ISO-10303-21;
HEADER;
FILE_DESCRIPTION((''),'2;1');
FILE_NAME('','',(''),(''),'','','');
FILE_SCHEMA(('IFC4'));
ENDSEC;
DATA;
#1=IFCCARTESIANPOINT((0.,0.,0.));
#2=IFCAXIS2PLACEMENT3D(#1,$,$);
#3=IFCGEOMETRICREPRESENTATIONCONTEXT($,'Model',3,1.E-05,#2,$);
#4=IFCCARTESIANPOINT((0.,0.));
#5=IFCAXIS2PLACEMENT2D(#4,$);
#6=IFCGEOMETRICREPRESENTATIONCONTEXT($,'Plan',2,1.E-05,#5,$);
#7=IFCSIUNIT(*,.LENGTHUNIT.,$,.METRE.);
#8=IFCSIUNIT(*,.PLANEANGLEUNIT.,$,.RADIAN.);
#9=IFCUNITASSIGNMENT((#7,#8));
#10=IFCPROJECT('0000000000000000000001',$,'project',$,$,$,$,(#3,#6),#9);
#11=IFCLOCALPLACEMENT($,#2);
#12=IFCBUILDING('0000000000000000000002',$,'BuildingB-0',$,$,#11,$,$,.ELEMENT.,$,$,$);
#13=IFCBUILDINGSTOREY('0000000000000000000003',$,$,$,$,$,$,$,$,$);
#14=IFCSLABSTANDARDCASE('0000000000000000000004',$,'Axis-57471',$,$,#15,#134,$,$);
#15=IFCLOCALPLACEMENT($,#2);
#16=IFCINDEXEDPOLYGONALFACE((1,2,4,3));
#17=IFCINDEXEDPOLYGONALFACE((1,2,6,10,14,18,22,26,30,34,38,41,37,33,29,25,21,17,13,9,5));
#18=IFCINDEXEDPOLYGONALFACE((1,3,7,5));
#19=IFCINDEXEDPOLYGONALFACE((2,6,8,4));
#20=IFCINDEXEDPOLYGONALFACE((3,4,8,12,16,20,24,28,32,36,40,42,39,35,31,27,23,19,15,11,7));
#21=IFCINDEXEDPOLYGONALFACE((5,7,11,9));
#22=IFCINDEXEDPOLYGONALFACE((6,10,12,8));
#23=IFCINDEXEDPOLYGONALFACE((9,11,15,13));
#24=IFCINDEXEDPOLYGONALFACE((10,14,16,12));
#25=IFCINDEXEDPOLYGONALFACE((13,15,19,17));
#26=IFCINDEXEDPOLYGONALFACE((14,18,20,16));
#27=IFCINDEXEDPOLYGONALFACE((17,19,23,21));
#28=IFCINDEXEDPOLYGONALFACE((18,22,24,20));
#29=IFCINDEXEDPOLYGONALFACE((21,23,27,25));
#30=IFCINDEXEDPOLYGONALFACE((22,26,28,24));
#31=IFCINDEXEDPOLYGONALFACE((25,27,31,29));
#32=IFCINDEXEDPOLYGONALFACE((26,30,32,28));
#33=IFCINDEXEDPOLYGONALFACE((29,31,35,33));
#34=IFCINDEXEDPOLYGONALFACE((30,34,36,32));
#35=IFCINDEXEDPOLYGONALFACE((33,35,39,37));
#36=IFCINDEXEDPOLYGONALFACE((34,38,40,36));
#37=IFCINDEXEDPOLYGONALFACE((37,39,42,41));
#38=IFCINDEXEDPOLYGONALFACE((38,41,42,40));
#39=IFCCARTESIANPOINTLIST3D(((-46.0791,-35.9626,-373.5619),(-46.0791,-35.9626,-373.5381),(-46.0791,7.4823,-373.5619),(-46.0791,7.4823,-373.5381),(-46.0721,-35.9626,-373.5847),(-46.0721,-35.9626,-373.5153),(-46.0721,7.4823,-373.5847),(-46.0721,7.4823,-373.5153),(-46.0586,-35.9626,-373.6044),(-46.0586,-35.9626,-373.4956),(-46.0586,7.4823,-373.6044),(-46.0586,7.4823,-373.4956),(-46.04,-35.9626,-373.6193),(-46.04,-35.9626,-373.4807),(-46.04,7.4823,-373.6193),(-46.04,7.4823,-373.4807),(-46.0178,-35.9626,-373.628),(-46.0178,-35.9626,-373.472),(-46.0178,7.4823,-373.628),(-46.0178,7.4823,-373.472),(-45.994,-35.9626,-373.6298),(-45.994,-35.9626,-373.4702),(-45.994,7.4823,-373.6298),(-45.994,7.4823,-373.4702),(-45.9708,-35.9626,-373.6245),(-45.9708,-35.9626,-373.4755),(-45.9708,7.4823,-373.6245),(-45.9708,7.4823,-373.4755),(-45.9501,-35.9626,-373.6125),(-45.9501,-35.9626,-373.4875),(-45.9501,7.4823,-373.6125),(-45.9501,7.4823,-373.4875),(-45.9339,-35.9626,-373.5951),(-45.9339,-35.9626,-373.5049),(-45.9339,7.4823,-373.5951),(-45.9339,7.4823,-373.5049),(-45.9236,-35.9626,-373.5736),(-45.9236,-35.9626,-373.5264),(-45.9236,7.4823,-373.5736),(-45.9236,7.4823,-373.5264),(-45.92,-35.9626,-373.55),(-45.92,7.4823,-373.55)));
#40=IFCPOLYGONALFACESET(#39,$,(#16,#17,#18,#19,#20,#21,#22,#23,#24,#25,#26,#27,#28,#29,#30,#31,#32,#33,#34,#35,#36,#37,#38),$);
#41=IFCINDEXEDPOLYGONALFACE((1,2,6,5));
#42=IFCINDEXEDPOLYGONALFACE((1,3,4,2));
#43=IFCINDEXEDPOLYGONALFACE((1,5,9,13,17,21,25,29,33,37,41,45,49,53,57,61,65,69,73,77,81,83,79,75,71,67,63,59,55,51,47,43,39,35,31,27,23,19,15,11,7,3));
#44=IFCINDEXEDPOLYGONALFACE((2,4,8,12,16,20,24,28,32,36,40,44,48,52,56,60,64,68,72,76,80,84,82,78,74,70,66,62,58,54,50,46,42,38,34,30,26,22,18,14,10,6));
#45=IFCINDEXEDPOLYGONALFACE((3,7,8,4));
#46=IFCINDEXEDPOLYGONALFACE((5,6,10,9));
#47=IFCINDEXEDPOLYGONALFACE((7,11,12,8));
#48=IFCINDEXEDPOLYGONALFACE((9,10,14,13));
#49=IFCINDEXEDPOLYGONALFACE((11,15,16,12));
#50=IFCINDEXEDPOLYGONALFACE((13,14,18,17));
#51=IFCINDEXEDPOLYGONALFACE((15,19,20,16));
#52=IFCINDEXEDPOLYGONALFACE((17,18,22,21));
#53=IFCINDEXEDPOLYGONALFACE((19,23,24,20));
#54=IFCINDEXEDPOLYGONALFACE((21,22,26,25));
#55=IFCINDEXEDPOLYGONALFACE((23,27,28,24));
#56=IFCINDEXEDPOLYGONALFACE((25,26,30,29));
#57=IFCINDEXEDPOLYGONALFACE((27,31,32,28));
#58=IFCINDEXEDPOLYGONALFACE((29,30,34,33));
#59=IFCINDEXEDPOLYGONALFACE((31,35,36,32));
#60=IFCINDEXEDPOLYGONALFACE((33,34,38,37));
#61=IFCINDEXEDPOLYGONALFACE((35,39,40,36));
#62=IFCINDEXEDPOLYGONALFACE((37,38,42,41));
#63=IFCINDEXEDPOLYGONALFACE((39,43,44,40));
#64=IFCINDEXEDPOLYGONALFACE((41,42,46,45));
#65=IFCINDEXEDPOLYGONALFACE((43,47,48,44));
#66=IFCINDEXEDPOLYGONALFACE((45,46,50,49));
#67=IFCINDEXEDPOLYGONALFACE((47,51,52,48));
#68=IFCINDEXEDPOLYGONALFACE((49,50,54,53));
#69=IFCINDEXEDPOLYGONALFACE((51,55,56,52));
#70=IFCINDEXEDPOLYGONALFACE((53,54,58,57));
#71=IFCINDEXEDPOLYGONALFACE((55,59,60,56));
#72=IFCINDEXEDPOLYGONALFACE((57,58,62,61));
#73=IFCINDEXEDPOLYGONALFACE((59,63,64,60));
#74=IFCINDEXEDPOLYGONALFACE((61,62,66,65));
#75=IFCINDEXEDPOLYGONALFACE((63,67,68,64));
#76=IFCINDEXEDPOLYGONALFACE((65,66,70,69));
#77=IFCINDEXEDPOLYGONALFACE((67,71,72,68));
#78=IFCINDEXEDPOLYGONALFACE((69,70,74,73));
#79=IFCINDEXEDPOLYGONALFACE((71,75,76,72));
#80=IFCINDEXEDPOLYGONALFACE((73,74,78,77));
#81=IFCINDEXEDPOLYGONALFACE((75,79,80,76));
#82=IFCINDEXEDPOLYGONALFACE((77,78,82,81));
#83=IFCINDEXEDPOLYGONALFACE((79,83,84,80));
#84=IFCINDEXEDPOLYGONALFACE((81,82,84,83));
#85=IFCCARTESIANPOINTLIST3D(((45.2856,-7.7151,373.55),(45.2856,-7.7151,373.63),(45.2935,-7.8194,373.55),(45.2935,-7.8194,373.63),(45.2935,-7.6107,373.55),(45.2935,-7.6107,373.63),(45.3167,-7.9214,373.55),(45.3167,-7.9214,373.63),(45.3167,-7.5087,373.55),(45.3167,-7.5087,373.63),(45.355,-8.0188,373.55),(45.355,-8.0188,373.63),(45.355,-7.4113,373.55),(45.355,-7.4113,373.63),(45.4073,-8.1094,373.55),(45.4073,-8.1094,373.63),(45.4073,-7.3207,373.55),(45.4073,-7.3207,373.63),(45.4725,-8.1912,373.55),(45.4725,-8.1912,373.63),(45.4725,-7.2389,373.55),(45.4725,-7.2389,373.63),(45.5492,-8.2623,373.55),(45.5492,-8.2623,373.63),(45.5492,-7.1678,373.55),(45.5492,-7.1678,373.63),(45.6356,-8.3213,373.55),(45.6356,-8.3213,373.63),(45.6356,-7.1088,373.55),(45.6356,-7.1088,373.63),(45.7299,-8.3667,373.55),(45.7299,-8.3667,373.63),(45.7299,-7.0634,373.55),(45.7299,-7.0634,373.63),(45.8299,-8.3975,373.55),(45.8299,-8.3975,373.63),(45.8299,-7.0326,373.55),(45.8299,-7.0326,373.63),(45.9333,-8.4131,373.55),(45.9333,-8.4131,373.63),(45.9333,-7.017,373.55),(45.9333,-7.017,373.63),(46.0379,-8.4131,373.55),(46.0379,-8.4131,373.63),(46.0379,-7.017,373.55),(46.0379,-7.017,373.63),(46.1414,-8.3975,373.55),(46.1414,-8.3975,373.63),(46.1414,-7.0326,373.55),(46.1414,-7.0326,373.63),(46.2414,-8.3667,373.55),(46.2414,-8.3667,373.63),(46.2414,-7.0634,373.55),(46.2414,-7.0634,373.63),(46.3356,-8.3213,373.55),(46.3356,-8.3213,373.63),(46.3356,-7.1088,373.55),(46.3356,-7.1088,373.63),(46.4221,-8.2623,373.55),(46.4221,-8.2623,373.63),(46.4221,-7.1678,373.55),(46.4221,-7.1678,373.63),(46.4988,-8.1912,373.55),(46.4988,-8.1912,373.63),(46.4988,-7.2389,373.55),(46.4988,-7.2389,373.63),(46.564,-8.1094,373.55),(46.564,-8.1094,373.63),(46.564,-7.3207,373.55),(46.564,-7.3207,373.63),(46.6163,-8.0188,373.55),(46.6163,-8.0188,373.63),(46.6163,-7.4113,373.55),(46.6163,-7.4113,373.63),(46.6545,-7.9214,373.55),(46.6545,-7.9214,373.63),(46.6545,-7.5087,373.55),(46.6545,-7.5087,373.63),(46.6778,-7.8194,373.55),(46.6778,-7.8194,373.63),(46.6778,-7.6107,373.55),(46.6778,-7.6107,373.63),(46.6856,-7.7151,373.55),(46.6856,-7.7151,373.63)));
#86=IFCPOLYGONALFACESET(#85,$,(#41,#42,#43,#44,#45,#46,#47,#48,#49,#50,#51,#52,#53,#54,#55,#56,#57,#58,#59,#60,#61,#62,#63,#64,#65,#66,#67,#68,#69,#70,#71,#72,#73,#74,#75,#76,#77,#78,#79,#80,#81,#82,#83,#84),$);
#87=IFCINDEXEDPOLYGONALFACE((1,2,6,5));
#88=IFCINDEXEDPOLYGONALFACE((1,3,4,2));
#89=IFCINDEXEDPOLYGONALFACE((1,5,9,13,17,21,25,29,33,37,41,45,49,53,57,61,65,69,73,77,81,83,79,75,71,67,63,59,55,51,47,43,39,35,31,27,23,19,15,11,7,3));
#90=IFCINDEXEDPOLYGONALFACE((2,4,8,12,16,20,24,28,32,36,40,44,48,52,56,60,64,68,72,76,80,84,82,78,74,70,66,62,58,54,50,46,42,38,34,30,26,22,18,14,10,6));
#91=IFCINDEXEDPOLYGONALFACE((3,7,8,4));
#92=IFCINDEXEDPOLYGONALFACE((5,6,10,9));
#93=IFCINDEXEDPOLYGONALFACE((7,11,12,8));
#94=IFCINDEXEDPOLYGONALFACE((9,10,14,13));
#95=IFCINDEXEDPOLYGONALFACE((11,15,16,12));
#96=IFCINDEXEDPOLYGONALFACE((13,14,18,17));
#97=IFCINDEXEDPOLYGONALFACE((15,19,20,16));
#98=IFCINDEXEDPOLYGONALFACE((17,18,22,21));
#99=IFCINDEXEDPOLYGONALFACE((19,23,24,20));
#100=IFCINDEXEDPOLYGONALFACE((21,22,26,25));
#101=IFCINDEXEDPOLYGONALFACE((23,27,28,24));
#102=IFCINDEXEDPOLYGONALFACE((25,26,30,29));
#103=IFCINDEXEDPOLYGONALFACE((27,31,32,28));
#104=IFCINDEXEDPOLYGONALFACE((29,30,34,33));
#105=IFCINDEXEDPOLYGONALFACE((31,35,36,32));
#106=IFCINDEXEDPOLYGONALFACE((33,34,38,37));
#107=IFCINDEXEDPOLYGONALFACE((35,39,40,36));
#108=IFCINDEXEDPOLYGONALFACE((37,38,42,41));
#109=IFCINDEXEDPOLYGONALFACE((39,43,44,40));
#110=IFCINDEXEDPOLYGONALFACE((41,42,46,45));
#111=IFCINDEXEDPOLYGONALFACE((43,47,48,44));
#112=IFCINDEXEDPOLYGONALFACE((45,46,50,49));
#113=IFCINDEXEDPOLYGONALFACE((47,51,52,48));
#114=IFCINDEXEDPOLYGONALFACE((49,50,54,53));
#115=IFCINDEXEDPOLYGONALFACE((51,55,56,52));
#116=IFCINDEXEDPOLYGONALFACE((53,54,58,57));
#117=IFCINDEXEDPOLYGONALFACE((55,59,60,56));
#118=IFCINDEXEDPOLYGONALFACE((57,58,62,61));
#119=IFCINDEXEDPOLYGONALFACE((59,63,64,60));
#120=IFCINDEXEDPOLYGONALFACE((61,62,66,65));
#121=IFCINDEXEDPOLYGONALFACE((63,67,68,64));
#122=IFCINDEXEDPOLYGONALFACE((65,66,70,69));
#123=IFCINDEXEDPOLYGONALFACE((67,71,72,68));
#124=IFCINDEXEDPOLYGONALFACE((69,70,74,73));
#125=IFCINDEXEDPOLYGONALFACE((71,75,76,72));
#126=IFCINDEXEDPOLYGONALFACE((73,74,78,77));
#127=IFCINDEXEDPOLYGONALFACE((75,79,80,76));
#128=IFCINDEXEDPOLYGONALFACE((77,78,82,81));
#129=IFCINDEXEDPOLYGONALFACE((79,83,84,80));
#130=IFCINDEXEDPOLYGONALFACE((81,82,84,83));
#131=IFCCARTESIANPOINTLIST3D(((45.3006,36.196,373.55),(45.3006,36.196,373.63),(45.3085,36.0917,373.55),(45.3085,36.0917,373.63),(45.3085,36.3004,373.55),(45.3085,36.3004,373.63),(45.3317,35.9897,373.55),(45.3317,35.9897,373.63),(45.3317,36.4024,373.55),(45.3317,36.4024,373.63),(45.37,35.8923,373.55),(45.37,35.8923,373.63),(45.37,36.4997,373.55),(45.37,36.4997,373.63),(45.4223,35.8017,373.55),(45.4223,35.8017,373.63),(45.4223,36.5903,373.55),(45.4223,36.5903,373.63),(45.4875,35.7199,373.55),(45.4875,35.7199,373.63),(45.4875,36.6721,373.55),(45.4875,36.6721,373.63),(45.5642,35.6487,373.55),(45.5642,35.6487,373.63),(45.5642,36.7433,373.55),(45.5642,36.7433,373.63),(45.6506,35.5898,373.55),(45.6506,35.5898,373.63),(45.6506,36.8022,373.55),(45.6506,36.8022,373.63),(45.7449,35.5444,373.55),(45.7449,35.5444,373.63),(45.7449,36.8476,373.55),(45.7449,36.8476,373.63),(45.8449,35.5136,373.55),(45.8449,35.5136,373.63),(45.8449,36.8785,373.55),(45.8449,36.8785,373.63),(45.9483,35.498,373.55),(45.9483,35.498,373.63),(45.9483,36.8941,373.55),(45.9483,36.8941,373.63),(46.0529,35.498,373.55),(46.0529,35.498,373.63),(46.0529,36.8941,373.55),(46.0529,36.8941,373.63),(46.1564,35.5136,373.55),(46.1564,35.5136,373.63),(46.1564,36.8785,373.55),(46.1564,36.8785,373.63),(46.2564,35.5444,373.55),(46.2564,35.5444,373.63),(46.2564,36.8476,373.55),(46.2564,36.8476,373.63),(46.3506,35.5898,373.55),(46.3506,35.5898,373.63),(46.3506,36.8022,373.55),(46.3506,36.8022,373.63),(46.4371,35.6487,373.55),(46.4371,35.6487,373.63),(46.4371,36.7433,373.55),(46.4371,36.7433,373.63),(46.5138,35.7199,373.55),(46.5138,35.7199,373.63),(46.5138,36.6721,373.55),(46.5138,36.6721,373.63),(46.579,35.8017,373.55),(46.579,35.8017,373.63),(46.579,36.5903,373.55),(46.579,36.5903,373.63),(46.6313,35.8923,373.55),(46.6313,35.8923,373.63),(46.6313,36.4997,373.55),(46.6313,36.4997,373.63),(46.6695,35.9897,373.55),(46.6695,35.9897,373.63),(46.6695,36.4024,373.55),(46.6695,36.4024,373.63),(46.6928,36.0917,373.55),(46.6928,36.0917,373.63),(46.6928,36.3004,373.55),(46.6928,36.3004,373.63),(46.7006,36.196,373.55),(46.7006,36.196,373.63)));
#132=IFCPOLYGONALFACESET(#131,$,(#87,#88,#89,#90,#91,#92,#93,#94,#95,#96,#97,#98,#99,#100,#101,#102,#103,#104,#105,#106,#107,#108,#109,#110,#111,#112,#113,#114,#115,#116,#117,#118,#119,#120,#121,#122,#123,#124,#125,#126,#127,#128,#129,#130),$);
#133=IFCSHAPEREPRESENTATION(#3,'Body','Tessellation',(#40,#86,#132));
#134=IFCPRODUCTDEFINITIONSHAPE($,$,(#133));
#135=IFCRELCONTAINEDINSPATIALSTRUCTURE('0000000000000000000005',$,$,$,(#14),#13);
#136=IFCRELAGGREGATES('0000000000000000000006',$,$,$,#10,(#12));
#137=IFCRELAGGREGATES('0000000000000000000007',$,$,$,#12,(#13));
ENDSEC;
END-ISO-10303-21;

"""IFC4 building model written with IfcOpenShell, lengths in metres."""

from ifc_helpers import new_model, entity, si_unit, frame, origin, origin_2d, place, context, project, spatial, circle, extrude, element, save


model = new_model("IFC4")

# Units and contexts
model_context = context("Model", 3, precision=1e-05, world=origin())
plan_context = context("Plan", 2, precision=1e-05, world=origin_2d())
ifc_project = project(units=[si_unit("LENGTHUNIT", "METRE"), si_unit("PLANEANGLEUNIT", "RADIAN")], contexts=[model_context, plan_context])

# Building, storey
building_placement = place(None, origin())
building = spatial("IfcBuilding", under=ifc_project, at=building_placement, Name="BuildingB-0", CompositionType="ELEMENT")
storey = spatial("IfcBuildingStorey", under=building)

# Slab
element("IfcSlabStandardCase", 1, inside=storey, Name="Axis-57471", context=model_context, shape_type="AdvancedSweptSolid", body=[
    entity("IfcSurfaceCurveSweptAreaSolid", entity("IfcCircleProfileDef", "AREA", None, None, 0.08), None, entity("IfcPolyline", [entity("IfcCartesianPoint", [46.0, -7.4823, 373.55]), entity("IfcCartesianPoint", [46.0, 35.9626, 373.55])]), None, None, entity("IfcPlane", entity("IfcAxis2Placement3D", entity("IfcCartesianPoint", [46.0, -7.4823, 373.55]), entity("IfcDirection", [0.0, 0.0, 1.0]), entity("IfcDirection", [1.0, 0.0, 0.0])))),
    extrude(circle(Radius=0.7), frame((45.9856, -7.7151, 373.55)), (0.0, 0.0, 1.0), 0.08),
    extrude(circle(Radius=0.7), frame((46.0006, 36.196, 373.55)), (0.0, 0.0, 1.0), 0.08),
])

save(model, "model.ifc")
